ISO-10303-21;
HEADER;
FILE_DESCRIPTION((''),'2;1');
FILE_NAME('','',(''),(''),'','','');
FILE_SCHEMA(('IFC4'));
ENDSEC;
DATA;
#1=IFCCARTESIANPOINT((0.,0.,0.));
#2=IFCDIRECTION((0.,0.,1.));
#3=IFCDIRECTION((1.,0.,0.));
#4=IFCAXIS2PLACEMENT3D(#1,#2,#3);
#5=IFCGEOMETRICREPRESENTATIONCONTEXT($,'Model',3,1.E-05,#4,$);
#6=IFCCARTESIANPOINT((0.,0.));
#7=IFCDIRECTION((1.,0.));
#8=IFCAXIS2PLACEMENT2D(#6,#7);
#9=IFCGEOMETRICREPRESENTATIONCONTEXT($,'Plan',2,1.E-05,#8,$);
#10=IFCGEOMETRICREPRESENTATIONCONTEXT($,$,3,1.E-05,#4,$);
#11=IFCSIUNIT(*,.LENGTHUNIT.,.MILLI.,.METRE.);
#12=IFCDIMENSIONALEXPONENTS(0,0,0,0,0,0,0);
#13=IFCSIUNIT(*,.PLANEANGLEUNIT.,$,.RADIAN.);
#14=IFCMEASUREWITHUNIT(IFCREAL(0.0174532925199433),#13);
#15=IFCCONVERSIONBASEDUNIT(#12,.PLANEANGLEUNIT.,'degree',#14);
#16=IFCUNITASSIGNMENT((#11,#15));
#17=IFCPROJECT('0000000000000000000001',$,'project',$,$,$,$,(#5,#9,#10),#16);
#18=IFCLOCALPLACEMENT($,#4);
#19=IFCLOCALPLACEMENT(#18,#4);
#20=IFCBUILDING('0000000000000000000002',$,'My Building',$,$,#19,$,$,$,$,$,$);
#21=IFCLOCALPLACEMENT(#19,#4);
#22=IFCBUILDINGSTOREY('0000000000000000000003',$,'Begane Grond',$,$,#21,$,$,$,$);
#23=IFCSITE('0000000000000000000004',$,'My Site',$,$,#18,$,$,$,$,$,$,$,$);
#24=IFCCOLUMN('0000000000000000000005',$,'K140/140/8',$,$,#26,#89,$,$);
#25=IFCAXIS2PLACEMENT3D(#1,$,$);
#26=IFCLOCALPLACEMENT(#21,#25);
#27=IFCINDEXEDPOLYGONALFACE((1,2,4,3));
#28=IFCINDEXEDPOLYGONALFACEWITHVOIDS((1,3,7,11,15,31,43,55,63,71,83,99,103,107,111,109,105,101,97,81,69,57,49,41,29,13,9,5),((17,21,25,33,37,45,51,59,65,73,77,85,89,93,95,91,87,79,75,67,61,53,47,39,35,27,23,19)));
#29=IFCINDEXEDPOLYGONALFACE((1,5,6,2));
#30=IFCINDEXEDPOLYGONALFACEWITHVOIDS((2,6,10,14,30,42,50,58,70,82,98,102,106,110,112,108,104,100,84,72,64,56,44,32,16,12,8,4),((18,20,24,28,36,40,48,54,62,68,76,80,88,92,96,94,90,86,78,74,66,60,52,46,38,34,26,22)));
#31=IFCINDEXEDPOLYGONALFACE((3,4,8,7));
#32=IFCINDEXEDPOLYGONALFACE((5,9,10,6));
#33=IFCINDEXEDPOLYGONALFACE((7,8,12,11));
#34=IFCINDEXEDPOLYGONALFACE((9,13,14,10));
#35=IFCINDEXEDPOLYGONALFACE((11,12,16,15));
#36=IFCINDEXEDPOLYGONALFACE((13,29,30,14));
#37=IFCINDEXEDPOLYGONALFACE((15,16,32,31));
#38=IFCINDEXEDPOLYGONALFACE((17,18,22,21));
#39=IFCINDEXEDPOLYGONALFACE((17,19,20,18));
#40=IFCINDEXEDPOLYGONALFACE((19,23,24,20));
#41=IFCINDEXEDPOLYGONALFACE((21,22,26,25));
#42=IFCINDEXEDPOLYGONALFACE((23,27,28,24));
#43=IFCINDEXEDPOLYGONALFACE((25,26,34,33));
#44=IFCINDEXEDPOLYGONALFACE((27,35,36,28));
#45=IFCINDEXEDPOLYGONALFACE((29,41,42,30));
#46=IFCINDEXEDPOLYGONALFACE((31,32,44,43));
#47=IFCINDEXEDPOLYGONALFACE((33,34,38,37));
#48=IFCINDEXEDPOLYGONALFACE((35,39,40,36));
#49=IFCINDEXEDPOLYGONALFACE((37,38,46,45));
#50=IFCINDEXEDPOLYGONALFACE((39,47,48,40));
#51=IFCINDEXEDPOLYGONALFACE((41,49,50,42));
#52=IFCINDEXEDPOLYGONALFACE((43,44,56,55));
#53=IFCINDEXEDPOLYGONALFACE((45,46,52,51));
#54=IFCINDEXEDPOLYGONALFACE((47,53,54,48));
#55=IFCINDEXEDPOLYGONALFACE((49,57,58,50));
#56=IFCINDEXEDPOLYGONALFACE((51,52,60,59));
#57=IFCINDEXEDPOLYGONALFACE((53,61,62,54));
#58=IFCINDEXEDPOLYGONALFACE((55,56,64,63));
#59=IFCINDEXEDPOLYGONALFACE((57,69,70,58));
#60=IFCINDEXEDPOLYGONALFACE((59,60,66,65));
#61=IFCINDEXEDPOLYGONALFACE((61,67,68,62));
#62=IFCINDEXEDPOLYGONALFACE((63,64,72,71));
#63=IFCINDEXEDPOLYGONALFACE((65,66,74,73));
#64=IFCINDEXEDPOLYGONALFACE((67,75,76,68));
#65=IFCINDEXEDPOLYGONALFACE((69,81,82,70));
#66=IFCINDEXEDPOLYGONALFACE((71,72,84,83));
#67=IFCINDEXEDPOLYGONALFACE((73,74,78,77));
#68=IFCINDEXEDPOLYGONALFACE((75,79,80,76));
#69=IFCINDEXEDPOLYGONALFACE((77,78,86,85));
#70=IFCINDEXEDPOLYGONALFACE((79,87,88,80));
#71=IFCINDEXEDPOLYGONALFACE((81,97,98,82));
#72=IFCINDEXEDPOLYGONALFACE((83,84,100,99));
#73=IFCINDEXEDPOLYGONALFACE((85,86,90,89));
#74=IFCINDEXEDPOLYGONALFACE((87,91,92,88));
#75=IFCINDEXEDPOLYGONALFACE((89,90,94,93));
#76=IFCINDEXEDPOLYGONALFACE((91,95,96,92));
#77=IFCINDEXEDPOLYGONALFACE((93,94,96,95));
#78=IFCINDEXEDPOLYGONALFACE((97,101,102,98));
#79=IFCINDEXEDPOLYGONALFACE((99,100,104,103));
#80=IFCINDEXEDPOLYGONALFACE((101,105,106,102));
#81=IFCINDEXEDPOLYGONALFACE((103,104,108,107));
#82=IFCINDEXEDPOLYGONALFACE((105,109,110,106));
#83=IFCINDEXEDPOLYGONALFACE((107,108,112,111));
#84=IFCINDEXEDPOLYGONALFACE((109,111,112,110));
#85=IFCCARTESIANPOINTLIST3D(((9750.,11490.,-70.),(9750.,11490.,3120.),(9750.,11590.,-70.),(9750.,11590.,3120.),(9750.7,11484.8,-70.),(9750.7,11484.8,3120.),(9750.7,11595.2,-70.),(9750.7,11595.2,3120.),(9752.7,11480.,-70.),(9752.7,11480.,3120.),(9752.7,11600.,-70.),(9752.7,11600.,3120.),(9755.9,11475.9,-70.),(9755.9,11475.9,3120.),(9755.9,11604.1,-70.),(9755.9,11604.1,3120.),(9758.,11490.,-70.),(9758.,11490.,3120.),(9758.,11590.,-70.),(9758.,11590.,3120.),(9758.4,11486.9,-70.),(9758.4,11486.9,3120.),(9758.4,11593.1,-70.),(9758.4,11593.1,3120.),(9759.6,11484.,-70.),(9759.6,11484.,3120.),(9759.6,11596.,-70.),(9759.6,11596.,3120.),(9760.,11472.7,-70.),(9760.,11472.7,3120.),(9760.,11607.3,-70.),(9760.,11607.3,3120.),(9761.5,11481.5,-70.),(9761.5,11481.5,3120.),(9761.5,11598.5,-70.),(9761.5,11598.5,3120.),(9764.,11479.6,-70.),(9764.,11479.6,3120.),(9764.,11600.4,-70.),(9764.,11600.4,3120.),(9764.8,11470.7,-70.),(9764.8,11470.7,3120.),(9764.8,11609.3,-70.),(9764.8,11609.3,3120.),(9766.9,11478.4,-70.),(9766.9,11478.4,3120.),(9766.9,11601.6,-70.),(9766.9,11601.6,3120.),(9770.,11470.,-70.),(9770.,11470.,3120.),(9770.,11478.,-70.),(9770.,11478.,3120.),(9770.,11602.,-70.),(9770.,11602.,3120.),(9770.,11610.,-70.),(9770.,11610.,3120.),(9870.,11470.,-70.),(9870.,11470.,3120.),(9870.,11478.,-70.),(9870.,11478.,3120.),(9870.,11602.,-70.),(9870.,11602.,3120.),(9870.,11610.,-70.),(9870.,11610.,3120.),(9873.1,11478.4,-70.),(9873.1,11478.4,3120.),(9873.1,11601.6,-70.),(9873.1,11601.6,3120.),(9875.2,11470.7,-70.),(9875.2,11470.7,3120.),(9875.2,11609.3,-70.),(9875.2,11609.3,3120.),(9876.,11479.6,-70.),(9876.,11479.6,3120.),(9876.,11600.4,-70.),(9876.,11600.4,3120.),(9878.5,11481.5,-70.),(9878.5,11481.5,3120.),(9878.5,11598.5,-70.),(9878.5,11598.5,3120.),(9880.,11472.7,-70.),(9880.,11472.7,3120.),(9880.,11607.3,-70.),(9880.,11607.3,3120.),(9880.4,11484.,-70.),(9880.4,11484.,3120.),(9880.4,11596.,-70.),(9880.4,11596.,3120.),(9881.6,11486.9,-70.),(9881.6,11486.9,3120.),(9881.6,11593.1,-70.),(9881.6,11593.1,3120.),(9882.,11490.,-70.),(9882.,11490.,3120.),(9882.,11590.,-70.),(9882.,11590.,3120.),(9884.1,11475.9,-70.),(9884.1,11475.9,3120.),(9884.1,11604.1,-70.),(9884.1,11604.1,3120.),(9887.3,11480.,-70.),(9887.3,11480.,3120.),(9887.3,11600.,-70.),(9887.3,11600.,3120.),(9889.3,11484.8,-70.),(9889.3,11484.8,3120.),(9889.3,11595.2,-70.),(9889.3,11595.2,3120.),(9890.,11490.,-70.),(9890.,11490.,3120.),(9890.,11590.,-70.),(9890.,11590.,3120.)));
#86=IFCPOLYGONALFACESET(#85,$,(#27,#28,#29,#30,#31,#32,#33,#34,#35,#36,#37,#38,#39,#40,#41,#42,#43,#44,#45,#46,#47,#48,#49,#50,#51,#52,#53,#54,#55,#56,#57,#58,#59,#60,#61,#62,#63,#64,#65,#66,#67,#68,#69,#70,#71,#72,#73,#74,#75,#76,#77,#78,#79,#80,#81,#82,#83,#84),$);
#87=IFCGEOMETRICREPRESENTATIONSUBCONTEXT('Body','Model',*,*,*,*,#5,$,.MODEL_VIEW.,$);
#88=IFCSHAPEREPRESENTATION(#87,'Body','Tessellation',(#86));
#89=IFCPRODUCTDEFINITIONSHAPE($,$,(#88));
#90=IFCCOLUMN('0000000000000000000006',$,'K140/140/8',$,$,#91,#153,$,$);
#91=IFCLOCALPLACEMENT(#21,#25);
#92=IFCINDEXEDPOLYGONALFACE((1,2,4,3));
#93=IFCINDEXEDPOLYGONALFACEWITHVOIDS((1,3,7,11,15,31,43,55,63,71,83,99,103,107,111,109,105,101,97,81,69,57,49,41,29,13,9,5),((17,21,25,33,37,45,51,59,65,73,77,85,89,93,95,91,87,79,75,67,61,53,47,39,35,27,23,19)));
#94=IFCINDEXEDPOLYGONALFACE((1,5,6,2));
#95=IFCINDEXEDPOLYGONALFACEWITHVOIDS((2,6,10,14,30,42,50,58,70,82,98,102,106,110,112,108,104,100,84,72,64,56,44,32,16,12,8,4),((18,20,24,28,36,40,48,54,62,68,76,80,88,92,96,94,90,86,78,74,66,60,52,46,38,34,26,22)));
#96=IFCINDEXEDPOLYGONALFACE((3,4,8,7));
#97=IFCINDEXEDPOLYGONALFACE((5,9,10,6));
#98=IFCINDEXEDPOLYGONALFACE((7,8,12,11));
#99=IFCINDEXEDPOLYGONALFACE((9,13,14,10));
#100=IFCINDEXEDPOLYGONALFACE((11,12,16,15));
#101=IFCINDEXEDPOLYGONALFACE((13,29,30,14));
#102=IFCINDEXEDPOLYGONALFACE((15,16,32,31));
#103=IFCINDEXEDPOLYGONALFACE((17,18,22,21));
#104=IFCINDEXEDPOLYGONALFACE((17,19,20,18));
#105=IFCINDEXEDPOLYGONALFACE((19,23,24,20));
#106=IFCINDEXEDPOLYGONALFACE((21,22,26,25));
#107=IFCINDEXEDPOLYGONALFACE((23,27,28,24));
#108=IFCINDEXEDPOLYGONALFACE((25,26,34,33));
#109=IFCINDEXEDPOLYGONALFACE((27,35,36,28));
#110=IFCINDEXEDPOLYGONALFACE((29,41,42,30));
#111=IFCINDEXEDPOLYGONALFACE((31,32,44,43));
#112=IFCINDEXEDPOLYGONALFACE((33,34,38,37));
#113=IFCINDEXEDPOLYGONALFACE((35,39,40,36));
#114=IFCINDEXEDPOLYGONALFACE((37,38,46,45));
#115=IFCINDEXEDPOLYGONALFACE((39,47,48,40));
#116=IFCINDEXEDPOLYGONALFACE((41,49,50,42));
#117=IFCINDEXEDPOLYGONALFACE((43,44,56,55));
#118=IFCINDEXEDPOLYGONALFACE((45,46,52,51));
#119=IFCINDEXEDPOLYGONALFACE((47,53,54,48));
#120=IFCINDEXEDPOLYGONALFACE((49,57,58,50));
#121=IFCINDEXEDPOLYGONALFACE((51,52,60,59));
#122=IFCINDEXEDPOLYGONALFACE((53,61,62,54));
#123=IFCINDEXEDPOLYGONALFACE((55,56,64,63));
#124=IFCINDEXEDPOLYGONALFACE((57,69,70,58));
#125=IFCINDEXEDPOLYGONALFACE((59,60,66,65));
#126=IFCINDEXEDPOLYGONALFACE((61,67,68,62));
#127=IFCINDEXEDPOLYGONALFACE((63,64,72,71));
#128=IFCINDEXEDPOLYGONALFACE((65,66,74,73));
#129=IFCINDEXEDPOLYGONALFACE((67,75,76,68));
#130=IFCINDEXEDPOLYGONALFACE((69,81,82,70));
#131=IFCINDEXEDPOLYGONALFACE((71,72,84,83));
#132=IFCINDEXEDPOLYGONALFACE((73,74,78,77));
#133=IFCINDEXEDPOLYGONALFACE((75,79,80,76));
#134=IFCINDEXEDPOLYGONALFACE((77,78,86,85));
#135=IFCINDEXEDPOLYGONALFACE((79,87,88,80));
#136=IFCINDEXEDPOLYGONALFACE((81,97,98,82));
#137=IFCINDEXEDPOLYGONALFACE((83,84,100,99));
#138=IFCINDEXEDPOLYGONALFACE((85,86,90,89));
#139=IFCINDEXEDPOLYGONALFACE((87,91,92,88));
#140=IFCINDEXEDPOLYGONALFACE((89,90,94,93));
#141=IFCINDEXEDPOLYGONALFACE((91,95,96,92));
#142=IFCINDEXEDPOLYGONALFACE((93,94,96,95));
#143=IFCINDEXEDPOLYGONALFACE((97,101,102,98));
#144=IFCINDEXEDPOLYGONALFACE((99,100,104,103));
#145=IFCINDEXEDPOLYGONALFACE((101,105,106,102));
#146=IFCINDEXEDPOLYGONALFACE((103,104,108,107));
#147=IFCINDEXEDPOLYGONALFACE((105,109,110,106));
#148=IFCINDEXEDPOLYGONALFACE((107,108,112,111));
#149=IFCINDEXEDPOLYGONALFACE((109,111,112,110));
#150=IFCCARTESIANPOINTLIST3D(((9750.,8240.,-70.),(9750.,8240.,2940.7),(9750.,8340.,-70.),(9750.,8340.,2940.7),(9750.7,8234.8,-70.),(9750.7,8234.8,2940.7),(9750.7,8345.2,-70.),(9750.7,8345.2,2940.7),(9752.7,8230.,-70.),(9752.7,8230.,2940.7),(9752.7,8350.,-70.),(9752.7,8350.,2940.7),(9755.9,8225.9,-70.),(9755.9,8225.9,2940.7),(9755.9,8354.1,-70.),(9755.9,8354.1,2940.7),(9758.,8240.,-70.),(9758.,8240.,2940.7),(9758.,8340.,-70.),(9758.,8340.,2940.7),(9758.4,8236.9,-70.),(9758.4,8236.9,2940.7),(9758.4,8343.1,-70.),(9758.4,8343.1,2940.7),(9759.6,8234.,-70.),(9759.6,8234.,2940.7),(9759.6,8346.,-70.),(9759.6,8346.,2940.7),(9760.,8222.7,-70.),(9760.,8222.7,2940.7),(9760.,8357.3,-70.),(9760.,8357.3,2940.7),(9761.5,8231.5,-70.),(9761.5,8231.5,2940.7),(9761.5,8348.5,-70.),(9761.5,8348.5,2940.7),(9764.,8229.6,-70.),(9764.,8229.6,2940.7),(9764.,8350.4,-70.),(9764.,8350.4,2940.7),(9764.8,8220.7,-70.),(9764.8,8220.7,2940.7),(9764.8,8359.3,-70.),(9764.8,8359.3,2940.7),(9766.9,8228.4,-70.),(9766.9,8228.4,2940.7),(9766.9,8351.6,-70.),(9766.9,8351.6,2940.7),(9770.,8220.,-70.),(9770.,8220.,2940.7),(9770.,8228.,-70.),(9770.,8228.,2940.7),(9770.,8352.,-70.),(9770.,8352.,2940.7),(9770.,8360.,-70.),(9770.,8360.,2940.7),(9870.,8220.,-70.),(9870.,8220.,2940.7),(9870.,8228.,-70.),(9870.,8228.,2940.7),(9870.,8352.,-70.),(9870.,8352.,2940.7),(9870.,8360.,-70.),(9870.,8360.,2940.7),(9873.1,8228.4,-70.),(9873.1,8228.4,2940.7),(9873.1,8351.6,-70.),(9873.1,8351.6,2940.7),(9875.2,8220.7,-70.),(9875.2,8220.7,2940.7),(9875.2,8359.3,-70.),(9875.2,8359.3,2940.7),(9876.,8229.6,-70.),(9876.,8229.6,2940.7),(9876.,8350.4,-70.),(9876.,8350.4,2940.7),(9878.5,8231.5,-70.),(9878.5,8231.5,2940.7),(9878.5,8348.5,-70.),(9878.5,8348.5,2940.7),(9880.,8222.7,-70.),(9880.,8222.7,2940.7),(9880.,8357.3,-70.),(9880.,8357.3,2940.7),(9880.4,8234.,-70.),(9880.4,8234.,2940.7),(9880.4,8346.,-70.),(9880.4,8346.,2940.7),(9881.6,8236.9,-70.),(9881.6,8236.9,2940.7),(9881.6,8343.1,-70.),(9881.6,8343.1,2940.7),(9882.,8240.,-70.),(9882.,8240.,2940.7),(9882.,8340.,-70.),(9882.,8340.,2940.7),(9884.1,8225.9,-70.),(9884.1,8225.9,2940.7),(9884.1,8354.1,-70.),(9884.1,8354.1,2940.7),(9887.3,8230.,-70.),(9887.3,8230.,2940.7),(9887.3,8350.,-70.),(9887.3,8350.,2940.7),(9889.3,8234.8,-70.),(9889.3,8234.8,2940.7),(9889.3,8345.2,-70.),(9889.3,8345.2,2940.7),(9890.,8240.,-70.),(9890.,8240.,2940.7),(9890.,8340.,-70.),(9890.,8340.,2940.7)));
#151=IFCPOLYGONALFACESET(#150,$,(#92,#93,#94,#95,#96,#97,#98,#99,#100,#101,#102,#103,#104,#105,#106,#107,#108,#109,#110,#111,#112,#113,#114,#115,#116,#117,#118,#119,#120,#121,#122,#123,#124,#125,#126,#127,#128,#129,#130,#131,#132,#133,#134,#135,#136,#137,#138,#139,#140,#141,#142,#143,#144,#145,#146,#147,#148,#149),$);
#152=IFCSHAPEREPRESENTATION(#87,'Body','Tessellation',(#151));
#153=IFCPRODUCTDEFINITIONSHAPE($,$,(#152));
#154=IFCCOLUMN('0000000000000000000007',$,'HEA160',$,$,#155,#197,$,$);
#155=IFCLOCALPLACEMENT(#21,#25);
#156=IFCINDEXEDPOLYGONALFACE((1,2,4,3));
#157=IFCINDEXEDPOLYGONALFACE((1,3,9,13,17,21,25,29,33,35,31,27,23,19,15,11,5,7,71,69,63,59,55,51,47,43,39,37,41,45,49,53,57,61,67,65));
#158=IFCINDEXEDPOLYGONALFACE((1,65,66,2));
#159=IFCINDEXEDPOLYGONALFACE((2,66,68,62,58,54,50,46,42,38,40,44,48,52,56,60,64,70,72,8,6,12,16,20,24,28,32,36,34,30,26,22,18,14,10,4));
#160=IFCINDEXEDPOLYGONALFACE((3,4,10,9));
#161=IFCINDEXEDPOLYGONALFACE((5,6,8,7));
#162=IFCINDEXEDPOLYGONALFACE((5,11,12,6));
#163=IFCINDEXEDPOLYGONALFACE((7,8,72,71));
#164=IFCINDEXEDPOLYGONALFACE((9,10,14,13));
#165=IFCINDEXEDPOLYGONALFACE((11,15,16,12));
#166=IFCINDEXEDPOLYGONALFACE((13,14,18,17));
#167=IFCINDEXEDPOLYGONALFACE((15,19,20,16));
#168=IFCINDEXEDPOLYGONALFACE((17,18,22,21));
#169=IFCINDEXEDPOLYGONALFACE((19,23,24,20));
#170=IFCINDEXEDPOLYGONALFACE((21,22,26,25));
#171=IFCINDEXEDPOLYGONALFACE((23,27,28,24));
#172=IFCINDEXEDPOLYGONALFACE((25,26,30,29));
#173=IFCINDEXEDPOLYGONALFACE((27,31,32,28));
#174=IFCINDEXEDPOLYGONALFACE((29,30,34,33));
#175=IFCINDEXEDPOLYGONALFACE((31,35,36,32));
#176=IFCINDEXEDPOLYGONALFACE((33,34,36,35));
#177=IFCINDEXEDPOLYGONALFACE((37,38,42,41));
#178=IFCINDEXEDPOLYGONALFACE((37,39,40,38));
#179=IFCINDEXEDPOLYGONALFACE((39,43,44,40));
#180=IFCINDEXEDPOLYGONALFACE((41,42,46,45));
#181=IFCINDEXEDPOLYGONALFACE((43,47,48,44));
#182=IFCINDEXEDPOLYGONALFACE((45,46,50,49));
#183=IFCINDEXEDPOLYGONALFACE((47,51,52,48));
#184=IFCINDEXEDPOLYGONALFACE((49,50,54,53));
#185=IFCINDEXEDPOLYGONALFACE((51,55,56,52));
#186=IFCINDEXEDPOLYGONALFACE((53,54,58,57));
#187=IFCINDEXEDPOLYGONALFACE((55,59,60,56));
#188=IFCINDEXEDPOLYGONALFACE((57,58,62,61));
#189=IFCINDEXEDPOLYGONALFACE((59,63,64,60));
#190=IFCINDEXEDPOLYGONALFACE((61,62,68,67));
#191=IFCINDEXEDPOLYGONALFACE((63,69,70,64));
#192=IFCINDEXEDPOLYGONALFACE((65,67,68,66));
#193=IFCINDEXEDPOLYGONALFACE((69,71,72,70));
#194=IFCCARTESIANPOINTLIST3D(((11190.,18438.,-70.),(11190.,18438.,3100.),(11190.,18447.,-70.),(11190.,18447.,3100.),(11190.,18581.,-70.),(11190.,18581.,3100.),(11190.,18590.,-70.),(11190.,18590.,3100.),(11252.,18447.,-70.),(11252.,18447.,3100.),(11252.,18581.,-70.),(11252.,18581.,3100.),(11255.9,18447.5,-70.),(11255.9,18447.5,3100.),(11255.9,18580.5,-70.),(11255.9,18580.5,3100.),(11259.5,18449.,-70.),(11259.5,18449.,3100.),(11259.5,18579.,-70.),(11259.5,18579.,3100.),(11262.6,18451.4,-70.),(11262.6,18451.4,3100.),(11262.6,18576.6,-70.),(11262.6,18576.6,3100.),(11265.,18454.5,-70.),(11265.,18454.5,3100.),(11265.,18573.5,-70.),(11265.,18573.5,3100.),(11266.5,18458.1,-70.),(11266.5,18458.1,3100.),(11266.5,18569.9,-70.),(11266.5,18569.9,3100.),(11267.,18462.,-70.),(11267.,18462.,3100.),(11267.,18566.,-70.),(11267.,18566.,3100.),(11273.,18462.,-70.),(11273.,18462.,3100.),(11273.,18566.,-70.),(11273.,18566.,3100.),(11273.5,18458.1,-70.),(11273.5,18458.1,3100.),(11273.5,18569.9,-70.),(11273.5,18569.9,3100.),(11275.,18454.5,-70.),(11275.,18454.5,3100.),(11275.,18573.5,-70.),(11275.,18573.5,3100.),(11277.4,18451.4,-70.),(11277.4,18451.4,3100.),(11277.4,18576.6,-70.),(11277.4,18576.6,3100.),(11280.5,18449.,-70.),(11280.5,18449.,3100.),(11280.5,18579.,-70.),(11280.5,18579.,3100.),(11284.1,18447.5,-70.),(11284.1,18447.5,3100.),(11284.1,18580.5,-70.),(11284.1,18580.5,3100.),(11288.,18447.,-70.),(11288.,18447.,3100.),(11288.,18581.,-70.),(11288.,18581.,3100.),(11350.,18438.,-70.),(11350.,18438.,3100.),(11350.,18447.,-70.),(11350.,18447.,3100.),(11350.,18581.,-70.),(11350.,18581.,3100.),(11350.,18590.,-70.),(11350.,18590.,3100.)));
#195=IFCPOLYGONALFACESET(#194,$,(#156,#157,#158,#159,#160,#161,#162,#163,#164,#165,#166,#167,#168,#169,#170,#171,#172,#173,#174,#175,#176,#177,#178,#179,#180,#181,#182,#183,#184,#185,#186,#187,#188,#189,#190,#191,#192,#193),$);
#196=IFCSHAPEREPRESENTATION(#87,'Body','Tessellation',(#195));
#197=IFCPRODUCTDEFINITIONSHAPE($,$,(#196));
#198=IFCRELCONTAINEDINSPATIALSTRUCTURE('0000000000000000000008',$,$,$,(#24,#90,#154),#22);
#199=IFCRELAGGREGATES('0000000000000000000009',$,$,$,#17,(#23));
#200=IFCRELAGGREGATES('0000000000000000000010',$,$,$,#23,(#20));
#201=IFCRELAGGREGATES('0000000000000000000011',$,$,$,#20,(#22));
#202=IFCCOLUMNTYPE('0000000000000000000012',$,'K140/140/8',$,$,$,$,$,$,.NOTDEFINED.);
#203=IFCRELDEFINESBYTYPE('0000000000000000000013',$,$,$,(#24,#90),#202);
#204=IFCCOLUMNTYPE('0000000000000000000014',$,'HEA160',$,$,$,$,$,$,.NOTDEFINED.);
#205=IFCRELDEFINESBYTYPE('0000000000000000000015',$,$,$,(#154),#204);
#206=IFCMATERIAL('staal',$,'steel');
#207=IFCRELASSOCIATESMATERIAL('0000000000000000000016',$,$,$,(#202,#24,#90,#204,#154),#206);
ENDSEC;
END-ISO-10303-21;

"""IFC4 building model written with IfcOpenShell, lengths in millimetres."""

from ifc_helpers import new_model, entity, si_unit, converted_unit, frame, origin_with_axes, origin_2d_with_axis, place, context, subcontext, project, spatial, hollow_rectangle, i_section, extrude, material, material_profile, profile_set, profile_usage, type_object, element, save


model = new_model("IFC4")

# Units and contexts
model_context = context("Model", 3, precision=1e-05, world=origin_with_axes())
plan_context = context("Plan", 2, precision=1e-05, world=origin_2d_with_axis())
context_of_model = context(None, 3, precision=1e-05, world=origin_with_axes())
body_context = subcontext(model_context, "Body", "Model", "MODEL_VIEW")
ifc_project = project(units=[si_unit("LENGTHUNIT", "METRE", prefix="MILLI"), converted_unit("PLANEANGLEUNIT", "degree", entity("IfcReal", 0.0174532925199433), si_unit("PLANEANGLEUNIT", "RADIAN"), dimensions=[0, 0, 0, 0, 0, 0, 0])], contexts=[model_context, plan_context, context_of_model])

# Site, building, storey
site_placement = place(None, origin_with_axes())
site = spatial("IfcSite", under=ifc_project, at=site_placement, Name="My Site")
building_placement = place(site_placement, origin_with_axes())
building = spatial("IfcBuilding", under=site, at=building_placement, Name="My Building")
storey_placement = place(building_placement, origin_with_axes())
storey = spatial("IfcBuildingStorey", under=building, at=storey_placement, Name="Begane Grond")

# Columns
ifc_material = material(Name="staal", Category="steel")
ifc_material_profile_1 = material_profile(ifc_material, hollow_rectangle(XDim=140.0, YDim=140.0, WallThickness=8.0, InnerFilletRadius=12.0, OuterFilletRadius=20.0))
ifc_profile_set_1 = profile_set([ifc_material_profile_1], Name="K140/140/8")
ifc_profile_usage_1 = profile_usage(ifc_profile_set_1, cardinal=5)
column_type_1 = type_object("IfcColumnType", Name="K140/140/8", PredefinedType="NOTDEFINED", material=ifc_profile_set_1)
column_1_placement = place(storey_placement, frame((9820.0, 11540.0, -70.0), z_axis=(0.0, 0.0, 1.0), x_axis=(1.0, 0.0, 0.0)))
element("IfcColumn", 1, at=column_1_placement, inside=storey, type_object=column_type_1, material=ifc_profile_usage_1, Name="K140/140/8", context=body_context, shape_type="SweptSolid", body=[
    extrude(hollow_rectangle(XDim=140.0, YDim=140.0, WallThickness=8.0, InnerFilletRadius=12.0, OuterFilletRadius=20.0), origin_with_axes(), (0.0, 0.0, 1.0), 3190.0),
])
ifc_profile_usage_2 = profile_usage(ifc_profile_set_1, cardinal=5)
column_2_placement = place(storey_placement, frame((9820.0, 8290.0, -70.0), z_axis=(0.0, 0.0, 1.0), x_axis=(1.0, 0.0, 0.0)))
element("IfcColumn", 2, at=column_2_placement, inside=storey, type_object=column_type_1, material=ifc_profile_usage_2, Name="K140/140/8", context=body_context, shape_type="SweptSolid", body=[
    extrude(hollow_rectangle(XDim=140.0, YDim=140.0, WallThickness=8.0, InnerFilletRadius=12.0, OuterFilletRadius=20.0), origin_with_axes(), (0.0, 0.0, 1.0), 3010.7),
])
ifc_material_profile_2 = material_profile(ifc_material, i_section(OverallWidth=160.0, OverallDepth=152.0, WebThickness=6.0, FlangeThickness=9.0, FilletRadius=15.0))
ifc_profile_set_2 = profile_set([ifc_material_profile_2], Name="HEA160")
ifc_profile_usage_3 = profile_usage(ifc_profile_set_2)
column_type_2 = type_object("IfcColumnType", Name="HEA160", PredefinedType="NOTDEFINED", material=ifc_profile_set_2)
column_3_placement = place(storey_placement, frame((11270.0, 18514.0, -70.0), z_axis=(0.0, 0.0, 1.0), x_axis=(1.0, 0.0, 0.0)))
element("IfcColumn", 3, at=column_3_placement, inside=storey, type_object=column_type_2, material=ifc_profile_usage_3, Name="HEA160", context=body_context, shape_type="SweptSolid", body=[
    extrude(i_section(OverallWidth=160.0, OverallDepth=152.0, WebThickness=6.0, FlangeThickness=9.0, FilletRadius=15.0), origin_with_axes(), (0.0, 0.0, 1.0), 3170.0),
])

save(model, "model.ifc")
